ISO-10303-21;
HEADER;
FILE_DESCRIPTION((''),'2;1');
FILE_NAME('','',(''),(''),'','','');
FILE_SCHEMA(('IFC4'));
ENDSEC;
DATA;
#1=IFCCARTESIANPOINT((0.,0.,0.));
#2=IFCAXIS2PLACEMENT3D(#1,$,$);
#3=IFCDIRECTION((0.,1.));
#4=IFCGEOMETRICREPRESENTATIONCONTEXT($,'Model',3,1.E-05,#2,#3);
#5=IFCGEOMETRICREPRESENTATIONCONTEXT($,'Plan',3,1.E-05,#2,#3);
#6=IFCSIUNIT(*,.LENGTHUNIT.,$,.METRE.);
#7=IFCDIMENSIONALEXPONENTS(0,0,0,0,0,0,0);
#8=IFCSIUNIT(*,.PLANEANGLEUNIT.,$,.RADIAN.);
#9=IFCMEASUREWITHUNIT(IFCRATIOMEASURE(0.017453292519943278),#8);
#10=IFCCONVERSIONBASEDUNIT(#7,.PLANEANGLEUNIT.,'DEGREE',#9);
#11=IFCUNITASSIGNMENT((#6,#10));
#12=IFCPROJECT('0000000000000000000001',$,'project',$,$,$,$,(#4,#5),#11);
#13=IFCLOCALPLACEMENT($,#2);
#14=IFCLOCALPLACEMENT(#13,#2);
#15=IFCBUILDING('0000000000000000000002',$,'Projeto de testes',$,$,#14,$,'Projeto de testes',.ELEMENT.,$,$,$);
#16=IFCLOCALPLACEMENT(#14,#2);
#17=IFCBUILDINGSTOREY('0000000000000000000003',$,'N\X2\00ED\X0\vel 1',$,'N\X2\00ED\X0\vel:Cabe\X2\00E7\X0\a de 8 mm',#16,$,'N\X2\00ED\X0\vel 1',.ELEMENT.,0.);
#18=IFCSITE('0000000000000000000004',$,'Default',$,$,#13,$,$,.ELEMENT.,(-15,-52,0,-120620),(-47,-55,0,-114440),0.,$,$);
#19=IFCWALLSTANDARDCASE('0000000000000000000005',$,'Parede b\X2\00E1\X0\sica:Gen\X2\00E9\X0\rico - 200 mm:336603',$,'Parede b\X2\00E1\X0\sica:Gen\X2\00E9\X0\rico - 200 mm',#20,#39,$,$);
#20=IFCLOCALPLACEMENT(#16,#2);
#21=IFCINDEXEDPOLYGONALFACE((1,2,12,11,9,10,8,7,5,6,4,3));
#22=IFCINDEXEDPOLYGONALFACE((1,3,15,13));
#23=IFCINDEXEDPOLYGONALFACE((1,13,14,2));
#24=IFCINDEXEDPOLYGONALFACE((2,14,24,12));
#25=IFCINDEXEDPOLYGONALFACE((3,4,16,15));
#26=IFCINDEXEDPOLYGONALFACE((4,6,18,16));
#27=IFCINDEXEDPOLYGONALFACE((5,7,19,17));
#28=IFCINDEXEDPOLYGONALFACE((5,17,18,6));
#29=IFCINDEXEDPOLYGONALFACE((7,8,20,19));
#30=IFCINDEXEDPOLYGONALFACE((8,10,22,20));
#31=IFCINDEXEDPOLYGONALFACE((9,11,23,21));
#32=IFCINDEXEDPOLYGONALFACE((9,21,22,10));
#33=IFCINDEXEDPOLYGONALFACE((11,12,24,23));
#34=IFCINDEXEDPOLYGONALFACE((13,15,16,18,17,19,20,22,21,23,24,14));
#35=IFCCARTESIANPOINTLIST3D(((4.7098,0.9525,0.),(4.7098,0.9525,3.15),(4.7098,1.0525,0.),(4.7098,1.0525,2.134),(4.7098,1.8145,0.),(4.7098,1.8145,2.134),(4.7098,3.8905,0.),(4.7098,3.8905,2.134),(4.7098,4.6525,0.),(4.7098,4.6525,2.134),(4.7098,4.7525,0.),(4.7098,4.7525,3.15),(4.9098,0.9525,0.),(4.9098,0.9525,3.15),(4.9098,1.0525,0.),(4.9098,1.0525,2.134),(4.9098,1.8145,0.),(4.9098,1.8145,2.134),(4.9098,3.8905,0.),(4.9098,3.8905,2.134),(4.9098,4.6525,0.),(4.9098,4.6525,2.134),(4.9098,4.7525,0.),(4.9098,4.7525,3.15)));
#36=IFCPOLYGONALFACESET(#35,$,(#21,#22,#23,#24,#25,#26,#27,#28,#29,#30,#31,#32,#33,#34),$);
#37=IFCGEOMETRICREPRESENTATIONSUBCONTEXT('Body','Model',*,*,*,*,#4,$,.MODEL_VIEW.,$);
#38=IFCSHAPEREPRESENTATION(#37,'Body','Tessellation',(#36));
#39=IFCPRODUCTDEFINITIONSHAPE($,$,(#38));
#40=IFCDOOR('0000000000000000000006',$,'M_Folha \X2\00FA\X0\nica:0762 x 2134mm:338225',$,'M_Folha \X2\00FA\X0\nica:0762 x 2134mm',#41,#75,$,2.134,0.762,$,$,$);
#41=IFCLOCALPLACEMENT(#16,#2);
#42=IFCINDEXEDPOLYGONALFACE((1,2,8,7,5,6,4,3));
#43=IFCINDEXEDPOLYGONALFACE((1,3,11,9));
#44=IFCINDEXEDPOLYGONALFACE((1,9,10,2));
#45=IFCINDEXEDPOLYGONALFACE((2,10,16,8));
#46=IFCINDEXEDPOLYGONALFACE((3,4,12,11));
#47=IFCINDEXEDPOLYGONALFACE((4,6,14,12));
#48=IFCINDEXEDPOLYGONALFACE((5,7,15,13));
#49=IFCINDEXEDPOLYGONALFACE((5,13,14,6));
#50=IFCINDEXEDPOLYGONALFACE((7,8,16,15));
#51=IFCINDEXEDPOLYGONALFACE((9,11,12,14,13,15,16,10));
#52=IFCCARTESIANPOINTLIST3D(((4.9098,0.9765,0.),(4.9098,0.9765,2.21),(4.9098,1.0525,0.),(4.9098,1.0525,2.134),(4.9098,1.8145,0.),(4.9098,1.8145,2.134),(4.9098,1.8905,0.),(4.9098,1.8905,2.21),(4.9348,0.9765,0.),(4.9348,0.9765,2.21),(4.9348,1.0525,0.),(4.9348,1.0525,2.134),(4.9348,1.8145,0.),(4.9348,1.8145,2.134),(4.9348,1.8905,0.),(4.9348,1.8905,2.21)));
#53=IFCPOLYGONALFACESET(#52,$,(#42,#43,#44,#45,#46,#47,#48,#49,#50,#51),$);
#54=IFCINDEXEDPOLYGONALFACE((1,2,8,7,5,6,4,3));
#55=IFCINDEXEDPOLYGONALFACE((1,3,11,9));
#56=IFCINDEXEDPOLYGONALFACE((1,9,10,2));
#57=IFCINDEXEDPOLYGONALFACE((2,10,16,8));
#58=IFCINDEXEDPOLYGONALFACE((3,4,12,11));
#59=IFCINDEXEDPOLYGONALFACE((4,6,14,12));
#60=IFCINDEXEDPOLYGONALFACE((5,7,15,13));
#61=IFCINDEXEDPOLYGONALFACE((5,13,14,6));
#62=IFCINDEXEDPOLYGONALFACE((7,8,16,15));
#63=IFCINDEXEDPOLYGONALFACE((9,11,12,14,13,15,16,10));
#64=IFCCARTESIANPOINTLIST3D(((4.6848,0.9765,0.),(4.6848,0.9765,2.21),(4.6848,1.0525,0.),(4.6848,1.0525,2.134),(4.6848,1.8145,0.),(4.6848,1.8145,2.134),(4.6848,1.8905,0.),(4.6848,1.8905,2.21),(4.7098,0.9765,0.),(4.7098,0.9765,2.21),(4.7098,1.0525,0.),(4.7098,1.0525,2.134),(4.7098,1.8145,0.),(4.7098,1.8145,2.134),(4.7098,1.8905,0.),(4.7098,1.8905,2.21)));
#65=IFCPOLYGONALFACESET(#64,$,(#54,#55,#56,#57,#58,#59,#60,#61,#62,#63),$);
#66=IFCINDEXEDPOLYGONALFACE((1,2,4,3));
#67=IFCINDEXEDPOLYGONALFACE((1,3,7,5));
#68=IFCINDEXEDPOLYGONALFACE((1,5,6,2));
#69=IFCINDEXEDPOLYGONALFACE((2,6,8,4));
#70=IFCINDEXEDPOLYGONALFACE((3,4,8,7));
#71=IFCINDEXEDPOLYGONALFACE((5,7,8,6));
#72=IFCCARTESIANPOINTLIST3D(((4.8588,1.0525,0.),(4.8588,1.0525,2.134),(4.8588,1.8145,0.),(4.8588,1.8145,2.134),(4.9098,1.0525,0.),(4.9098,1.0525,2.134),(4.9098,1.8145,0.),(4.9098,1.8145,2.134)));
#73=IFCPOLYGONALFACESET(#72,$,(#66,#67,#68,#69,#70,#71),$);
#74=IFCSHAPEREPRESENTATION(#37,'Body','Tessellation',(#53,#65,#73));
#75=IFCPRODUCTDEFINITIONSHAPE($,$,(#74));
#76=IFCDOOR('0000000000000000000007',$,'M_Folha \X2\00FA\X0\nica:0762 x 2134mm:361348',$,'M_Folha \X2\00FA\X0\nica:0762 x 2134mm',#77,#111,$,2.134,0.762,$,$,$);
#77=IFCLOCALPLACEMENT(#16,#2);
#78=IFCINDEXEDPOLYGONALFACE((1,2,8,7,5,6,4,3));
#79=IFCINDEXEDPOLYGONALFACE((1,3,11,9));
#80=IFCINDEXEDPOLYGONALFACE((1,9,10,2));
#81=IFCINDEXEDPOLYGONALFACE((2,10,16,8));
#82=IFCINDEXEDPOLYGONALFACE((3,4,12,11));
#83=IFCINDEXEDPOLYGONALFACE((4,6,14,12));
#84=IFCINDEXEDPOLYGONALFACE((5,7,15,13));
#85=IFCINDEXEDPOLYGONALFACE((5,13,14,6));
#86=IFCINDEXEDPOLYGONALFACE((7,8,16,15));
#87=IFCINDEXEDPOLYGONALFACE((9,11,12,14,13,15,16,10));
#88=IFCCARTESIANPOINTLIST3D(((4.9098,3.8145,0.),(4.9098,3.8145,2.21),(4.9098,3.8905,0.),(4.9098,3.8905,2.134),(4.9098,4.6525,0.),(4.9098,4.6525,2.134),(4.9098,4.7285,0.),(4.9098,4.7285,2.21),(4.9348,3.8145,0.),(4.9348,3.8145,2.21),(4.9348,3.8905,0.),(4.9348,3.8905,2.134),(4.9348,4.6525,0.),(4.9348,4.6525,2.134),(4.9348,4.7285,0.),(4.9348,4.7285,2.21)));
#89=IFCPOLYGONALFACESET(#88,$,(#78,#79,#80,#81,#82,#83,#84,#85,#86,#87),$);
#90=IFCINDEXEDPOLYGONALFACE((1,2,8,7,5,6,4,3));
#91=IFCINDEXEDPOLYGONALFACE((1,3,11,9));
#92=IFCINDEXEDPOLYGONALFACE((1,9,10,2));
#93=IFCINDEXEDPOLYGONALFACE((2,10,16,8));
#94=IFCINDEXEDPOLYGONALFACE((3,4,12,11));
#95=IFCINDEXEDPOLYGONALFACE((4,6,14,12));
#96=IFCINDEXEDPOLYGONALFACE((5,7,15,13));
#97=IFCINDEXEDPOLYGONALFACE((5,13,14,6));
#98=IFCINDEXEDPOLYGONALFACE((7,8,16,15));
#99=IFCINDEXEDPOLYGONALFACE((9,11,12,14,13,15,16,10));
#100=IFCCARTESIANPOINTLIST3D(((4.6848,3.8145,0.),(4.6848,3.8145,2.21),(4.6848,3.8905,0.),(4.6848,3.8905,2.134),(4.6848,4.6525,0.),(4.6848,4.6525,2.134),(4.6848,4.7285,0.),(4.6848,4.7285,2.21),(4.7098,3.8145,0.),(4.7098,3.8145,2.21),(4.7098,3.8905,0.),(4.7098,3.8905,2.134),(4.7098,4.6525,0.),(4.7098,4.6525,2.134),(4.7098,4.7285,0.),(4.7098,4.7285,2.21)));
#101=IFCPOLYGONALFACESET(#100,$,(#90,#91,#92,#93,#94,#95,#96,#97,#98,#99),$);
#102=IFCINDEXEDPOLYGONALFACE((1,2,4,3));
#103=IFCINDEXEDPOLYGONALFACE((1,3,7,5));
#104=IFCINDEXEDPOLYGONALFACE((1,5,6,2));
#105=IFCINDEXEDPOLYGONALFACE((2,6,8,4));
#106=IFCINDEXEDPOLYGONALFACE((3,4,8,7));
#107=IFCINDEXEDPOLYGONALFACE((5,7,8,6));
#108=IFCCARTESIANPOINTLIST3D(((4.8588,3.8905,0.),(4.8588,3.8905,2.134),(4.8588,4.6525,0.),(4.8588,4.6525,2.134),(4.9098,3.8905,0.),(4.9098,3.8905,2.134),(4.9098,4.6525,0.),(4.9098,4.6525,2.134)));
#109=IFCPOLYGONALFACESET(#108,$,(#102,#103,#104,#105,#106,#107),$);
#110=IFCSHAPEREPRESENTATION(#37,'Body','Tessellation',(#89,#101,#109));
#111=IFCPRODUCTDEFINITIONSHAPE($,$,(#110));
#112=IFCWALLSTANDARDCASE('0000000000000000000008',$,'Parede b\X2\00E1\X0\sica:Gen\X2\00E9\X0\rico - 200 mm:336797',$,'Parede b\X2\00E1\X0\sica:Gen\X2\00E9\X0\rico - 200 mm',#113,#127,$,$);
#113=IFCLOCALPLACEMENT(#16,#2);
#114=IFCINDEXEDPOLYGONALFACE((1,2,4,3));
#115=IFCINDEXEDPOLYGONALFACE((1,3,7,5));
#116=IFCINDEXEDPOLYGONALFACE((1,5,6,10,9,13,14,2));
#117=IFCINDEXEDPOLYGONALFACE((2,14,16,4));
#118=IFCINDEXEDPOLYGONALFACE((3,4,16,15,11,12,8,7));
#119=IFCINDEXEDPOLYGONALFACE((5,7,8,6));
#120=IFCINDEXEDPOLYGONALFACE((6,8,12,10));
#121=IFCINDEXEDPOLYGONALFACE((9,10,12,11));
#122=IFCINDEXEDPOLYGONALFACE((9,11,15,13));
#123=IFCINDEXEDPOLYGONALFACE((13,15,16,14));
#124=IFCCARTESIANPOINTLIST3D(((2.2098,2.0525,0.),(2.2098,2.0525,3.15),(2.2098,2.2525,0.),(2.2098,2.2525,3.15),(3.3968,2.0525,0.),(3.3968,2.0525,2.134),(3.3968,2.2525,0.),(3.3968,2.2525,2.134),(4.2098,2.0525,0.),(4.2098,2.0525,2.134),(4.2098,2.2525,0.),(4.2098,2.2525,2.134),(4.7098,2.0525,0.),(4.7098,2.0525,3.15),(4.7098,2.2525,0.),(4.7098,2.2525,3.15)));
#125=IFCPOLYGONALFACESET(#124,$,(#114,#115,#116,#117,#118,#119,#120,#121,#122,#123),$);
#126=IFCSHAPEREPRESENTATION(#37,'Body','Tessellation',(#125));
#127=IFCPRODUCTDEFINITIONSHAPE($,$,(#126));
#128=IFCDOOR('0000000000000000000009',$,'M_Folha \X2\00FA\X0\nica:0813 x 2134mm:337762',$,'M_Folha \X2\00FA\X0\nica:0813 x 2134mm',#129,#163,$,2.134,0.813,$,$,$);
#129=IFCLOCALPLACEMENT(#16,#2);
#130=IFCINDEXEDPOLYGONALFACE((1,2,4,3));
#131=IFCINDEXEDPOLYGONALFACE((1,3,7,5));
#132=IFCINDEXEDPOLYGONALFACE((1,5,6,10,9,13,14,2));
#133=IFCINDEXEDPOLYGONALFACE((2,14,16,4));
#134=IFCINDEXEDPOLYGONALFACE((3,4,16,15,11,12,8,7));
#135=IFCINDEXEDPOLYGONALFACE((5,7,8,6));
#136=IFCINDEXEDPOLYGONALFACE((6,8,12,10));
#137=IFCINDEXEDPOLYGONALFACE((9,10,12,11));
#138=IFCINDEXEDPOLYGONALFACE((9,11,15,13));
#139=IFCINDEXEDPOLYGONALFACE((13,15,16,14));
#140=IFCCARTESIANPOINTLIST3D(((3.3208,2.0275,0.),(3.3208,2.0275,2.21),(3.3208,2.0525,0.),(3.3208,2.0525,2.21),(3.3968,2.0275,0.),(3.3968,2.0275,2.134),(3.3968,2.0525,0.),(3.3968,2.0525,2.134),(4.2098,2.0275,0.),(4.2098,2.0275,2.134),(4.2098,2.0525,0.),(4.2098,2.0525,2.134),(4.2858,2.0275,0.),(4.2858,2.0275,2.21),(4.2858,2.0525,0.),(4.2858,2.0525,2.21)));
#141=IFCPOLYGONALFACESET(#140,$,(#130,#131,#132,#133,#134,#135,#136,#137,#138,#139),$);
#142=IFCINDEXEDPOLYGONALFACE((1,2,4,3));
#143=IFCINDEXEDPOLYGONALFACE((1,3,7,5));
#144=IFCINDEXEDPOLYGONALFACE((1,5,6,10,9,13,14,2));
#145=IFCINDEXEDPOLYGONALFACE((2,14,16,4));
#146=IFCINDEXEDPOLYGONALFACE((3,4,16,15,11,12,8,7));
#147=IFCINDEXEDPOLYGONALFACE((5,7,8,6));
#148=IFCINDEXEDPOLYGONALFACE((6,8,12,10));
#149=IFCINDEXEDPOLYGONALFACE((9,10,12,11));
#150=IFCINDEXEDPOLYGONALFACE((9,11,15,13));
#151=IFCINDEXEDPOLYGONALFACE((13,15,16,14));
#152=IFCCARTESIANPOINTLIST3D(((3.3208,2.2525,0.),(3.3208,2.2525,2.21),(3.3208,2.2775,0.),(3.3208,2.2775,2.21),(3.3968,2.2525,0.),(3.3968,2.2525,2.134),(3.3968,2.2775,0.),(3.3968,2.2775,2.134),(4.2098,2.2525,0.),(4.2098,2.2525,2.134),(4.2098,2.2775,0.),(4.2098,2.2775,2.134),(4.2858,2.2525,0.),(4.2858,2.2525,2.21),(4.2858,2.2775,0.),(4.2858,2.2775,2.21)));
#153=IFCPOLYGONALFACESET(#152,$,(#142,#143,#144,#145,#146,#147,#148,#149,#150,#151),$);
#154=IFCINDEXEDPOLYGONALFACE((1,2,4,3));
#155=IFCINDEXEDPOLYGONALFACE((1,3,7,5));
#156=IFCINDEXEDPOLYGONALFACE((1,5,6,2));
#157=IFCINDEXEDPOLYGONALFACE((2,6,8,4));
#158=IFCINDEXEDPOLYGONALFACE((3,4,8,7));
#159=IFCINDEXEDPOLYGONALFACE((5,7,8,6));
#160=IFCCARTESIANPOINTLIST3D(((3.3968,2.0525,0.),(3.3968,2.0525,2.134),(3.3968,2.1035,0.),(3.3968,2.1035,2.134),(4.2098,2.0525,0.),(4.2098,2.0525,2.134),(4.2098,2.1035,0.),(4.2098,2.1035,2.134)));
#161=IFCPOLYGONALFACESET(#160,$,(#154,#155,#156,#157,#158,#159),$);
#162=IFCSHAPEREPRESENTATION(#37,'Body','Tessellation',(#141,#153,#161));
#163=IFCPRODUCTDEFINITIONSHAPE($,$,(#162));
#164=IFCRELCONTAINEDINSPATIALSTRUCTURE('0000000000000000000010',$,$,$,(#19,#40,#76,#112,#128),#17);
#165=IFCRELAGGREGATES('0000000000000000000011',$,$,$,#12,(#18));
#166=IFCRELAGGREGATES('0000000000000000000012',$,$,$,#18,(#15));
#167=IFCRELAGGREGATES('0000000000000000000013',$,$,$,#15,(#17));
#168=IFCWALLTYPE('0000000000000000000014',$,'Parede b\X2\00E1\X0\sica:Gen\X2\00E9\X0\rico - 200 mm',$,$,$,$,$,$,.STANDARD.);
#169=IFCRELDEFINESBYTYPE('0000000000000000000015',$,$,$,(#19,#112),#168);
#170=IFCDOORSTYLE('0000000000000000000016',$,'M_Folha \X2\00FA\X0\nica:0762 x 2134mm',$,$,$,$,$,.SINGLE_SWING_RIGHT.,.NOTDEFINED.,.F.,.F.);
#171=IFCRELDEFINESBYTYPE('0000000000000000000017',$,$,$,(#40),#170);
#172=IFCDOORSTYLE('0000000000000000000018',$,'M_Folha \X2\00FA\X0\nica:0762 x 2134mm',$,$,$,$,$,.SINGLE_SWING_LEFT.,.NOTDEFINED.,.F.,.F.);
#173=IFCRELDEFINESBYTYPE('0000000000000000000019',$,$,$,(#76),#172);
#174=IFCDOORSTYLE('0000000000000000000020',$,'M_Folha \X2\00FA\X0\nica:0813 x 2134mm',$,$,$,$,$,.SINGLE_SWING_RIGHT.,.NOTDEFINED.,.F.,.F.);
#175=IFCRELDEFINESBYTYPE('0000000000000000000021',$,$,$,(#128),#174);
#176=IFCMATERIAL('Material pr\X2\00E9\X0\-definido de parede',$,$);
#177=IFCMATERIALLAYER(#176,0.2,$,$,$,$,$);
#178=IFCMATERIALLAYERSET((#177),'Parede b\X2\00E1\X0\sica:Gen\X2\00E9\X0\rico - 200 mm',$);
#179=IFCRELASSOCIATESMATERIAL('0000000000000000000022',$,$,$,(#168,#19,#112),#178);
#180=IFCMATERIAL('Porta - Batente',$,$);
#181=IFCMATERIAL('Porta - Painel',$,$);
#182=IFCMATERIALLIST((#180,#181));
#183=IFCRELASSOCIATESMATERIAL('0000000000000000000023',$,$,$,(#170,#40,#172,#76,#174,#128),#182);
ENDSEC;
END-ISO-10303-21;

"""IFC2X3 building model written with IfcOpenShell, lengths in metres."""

from ifc_helpers import new_model, entity, si_unit, converted_unit, direction, frame, frame_2d, origin, place, context, subcontext, project, spatial, polyline, rectangle, outline, extrude, source, transform, mapped, material, material_list, layer, layer_set, layer_usage, type_object, type_shapes, element, fill, save


model = new_model("IFC2X3")

# Units and contexts
model_context = context("Model", 3, precision=1e-05, world=origin(), true_north=direction((0.0, 1.0)))
plan_context = context("Plan", 3, precision=1e-05, world=origin(), true_north=direction((0.0, 1.0)))
body_context = subcontext(model_context, "Body", "Model", "MODEL_VIEW")
ifc_project = project(units=[si_unit("LENGTHUNIT", "METRE"), converted_unit("PLANEANGLEUNIT", "DEGREE", entity("IfcRatioMeasure", 0.017453292519943278), si_unit("PLANEANGLEUNIT", "RADIAN"), dimensions=[0, 0, 0, 0, 0, 0, 0])], contexts=[model_context, plan_context])

# Site, building, storey
site_placement = place(None, origin())
site = spatial("IfcSite", under=ifc_project, at=site_placement, Name="Default", CompositionType="ELEMENT", RefLatitude=(-15, -52, 0, -120620), RefLongitude=(-47, -55, 0, -114440), RefElevation=0.0)
building_placement = place(site_placement, origin())
building = spatial("IfcBuilding", under=site, at=building_placement, Name="Projeto de testes", LongName="Projeto de testes", CompositionType="ELEMENT")
storey_placement = place(building_placement, origin())
storey = spatial("IfcBuildingStorey", under=building, at=storey_placement, Name="Nível 1", ObjectType="Nível:Cabeça de 8 mm", LongName="Nível 1", CompositionType="ELEMENT", Elevation=0.0)

# Shared definitions
ifc_material_1 = material(Name="Material pré-definido de parede")
ifc_layer = layer(ifc_material_1, 0.2)
ifc_layer_set = layer_set([ifc_layer], Name="Parede básica:Genérico - 200 mm")
wall_type = type_object("IfcWallType", Name="Parede básica:Genérico - 200 mm", PredefinedType="STANDARD", material=ifc_layer_set)

# Shared definitions
ifc_material_2 = material(Name="Porta - Batente")
ifc_material_3 = material(Name="Porta - Painel")
ifc_material_list_1 = material_list([ifc_material_2, ifc_material_3])

# Shared definitions
ifc_layer_usage_1 = layer_usage(ifc_layer_set, "AXIS2", "NEGATIVE", 0.1)

# Wall, openings, doors
wall_1_placement = place(storey_placement, frame((4.8098, 0.9525, 0.0), z_axis=(0.0, 0.0, 1.0), x_axis=(0.0, 1.0, 0.0)))
wall_1 = element("IfcWallStandardCase", 1, at=wall_1_placement, inside=storey, type_object=wall_type, material=ifc_layer_usage_1, Name="Parede básica:Genérico - 200 mm:336603", ObjectType="Parede básica:Genérico - 200 mm", context=body_context, shape_type="SweptSolid", body=[
    extrude(rectangle(XDim=3.8, YDim=0.2, at=frame_2d((1.9, 0.0), x_axis=(-1.0, 0.0))), origin(), (0.0, 0.0, 1.0), 3.15),
])
opening_1_placement = place(wall_1_placement, frame((0.862, 0.1, 0.0)))
opening_1 = element("IfcOpeningElement", 2, at=opening_1_placement, cuts=wall_1, ObjectType="Opening", context=body_context, shape_type="SweptSolid", body=[
    extrude(rectangle(XDim=0.762, YDim=2.134, at=frame_2d((1.067, 0.381), x_axis=(0.0, 1.0))), frame((0.0, 0.0, 0.0), z_axis=(0.0, -1.0, 0.0), x_axis=(0.0, 0.0, 1.0)), (0.0, 0.0, 1.0), 0.2),
])
opening_2_placement = place(wall_1_placement, frame((3.7, 0.1, 0.0)))
opening_2 = element("IfcOpeningElement", 3, at=opening_2_placement, cuts=wall_1, ObjectType="Opening", context=body_context, shape_type="SweptSolid", body=[
    extrude(rectangle(XDim=0.762, YDim=2.134, at=frame_2d((1.067, 0.381), x_axis=(0.0, -1.0))), frame((0.0, 0.0, 0.0), z_axis=(0.0, -1.0, 0.0), x_axis=(0.0, 0.0, 1.0)), (0.0, 0.0, 1.0), 0.2),
])
door_style_1 = type_object("IfcDoorStyle", Name="M_Folha única:0762 x 2134mm", ConstructionType="NOTDEFINED", OperationType="SINGLE_SWING_RIGHT", ParameterTakesPrecedence=False, Sizeable=False, material=ifc_material_list_1)
shared_shape_1 = source(origin(), body_context, "Body", "SweptSolid", [
    extrude(outline(polyline([(-0.457, -1.124), (0.457, -1.124), (0.457, 1.086), (0.381, 1.086), (0.381, -1.048), (-0.381, -1.048), (-0.381, 1.086), (-0.457, 1.086), (-0.457, -1.124)])), frame((0.381, 0.2, 1.086), z_axis=(0.0, 1.0, 0.0), x_axis=(1.0, 0.0, 0.0)), (0.0, 0.0, 1.0), 0.025),
    extrude(outline(polyline([(-1.124, -0.457), (1.086, -0.457), (1.086, -0.381), (-1.048, -0.381), (-1.048, 0.381), (1.086, 0.381), (1.086, 0.457), (-1.124, 0.457), (-1.124, -0.457)])), frame((0.381, -0.025, 1.086), z_axis=(0.0, 1.0, 0.0), x_axis=(0.0, 0.0, -1.0)), (0.0, 0.0, 1.0), 0.025),
    extrude(rectangle(XDim=0.051, YDim=0.762, at=frame_2d((0.0, 0.0), x_axis=(1.0, 0.0))), frame((0.381, 0.1745, 0.0), z_axis=(0.0, 0.0, 1.0), x_axis=(0.0, 1.0, 0.0)), (0.0, 0.0, 1.0), 2.134),
])
type_shapes(door_style_1, [shared_shape_1])
door_1_placement = place(opening_1_placement, frame((0.0, 0.0, 0.0), z_axis=(0.0, 0.0, 1.0), x_axis=(-1.0, 0.0, 0.0)))
door_1 = element("IfcDoor", 4, at=door_1_placement, inside=storey, type_object=door_style_1, material=ifc_material_list_1, Name="M_Folha única:0762 x 2134mm:338225", ObjectType="M_Folha única:0762 x 2134mm", OverallHeight=2.134, OverallWidth=0.762, context=body_context, shape_type="MappedRepresentation", body=[
    mapped(shared_shape_1, transform((0.0, 0.0, 0.0), scale=1.0)),
])
fill(opening_1, door_1)
door_style_2 = type_object("IfcDoorStyle", Name="M_Folha única:0762 x 2134mm", ConstructionType="NOTDEFINED", OperationType="SINGLE_SWING_LEFT", ParameterTakesPrecedence=False, Sizeable=False, material=ifc_material_list_1)
shared_shape_2 = source(origin(), body_context, "Body", "SweptSolid", [
    extrude(outline(polyline([(-0.457, -1.124), (0.457, -1.124), (0.457, 1.086), (0.381, 1.086), (0.381, -1.048), (-0.381, -1.048), (-0.381, 1.086), (-0.457, 1.086), (-0.457, -1.124)])), frame((0.381, 0.225, 1.086), z_axis=(0.0, -1.0, 0.0), x_axis=(-1.0, 0.0, 0.0)), (0.0, 0.0, 1.0), 0.025),
    extrude(outline(polyline([(-1.124, -0.457), (1.086, -0.457), (1.086, -0.381), (-1.048, -0.381), (-1.048, 0.381), (1.086, 0.381), (1.086, 0.457), (-1.124, 0.457), (-1.124, -0.457)])), frame((0.381, 0.0, 1.086), z_axis=(0.0, -1.0, 0.0), x_axis=(0.0, 0.0, -1.0)), (0.0, 0.0, 1.0), 0.025),
    extrude(rectangle(XDim=0.762, YDim=0.051, at=frame_2d((0.0, 0.0), x_axis=(1.0, 0.0))), frame((0.381, 0.1745, 0.0)), (0.0, 0.0, 1.0), 2.134),
])
type_shapes(door_style_2, [shared_shape_2])
door_2_placement = place(opening_2_placement, frame((0.0, 0.0, 0.0), z_axis=(0.0, 0.0, 1.0), x_axis=(-1.0, 0.0, 0.0)))
door_2 = element("IfcDoor", 5, at=door_2_placement, inside=storey, type_object=door_style_2, material=ifc_material_list_1, Name="M_Folha única:0762 x 2134mm:361348", ObjectType="M_Folha única:0762 x 2134mm", OverallHeight=2.134, OverallWidth=0.762, context=body_context, shape_type="MappedRepresentation", body=[
    mapped(shared_shape_2, transform((0.0, 0.0, 0.0), scale=1.0)),
])
fill(opening_2, door_2)

# Wall, opening, door
wall_2_placement = place(storey_placement, frame((4.7098, 2.1525, 0.0), z_axis=(0.0, 0.0, 1.0), x_axis=(-1.0, 0.0, 0.0)))
wall_2 = element("IfcWallStandardCase", 6, at=wall_2_placement, inside=storey, type_object=wall_type, material=ifc_layer_usage_1, Name="Parede básica:Genérico - 200 mm:336797", ObjectType="Parede básica:Genérico - 200 mm", context=body_context, shape_type="SweptSolid", body=[
    extrude(rectangle(XDim=2.5, YDim=0.2, at=frame_2d((1.25, 0.0), x_axis=(-1.0, 0.0))), origin(), (0.0, 0.0, 1.0), 3.15),
])
opening_3_placement = place(wall_2_placement, frame((0.5, -0.1, 0.0)))
opening_3 = element("IfcOpeningElement", 7, at=opening_3_placement, cuts=wall_2, ObjectType="Opening", context=body_context, shape_type="SweptSolid", body=[
    extrude(rectangle(XDim=0.813, YDim=2.134, at=frame_2d((1.067, 0.4065), x_axis=(0.0, 1.0))), frame((0.0, 0.0, 0.0), z_axis=(0.0, 1.0, 0.0), x_axis=(0.0, 0.0, 1.0)), (0.0, 0.0, 1.0), 0.2),
])
door_style_3 = type_object("IfcDoorStyle", Name="M_Folha única:0813 x 2134mm", ConstructionType="NOTDEFINED", OperationType="SINGLE_SWING_RIGHT", ParameterTakesPrecedence=False, Sizeable=False, material=ifc_material_list_1)
shared_shape_3 = source(origin(), body_context, "Body", "SweptSolid", [
    extrude(outline(polyline([(-0.4825, -1.124), (0.4825, -1.124), (0.4825, 1.086), (0.4065, 1.086), (0.4065, -1.048), (-0.4065, -1.048), (-0.4065, 1.086), (-0.4825, 1.086), (-0.4825, -1.124)])), frame((0.4065, 0.2, 1.086), z_axis=(0.0, 1.0, 0.0), x_axis=(1.0, 0.0, 0.0)), (0.0, 0.0, 1.0), 0.025),
    extrude(outline(polyline([(-1.124, -0.4825), (1.086, -0.4825), (1.086, -0.4065), (-1.048, -0.4065), (-1.048, 0.4065), (1.086, 0.4065), (1.086, 0.4825), (-1.124, 0.4825), (-1.124, -0.4825)])), frame((0.4065, -0.025, 1.086), z_axis=(0.0, 1.0, 0.0), x_axis=(0.0, 0.0, -1.0)), (0.0, 0.0, 1.0), 0.025),
    extrude(rectangle(XDim=0.051, YDim=0.813, at=frame_2d((0.0, 0.0), x_axis=(1.0, 0.0))), frame((0.4065, 0.1745, 0.0), z_axis=(0.0, 0.0, 1.0), x_axis=(0.0, 1.0, 0.0)), (0.0, 0.0, 1.0), 2.134),
])
type_shapes(door_style_3, [shared_shape_3])
door_3_placement = place(opening_3_placement, origin())
door_3 = element("IfcDoor", 8, at=door_3_placement, inside=storey, type_object=door_style_3, material=ifc_material_list_1, Name="M_Folha única:0813 x 2134mm:337762", ObjectType="M_Folha única:0813 x 2134mm", OverallHeight=2.134, OverallWidth=0.813, context=body_context, shape_type="MappedRepresentation", body=[
    mapped(shared_shape_3, transform((0.0, 0.0, 0.0), scale=1.0)),
])
fill(opening_3, door_3)

save(model, "model.ifc")
